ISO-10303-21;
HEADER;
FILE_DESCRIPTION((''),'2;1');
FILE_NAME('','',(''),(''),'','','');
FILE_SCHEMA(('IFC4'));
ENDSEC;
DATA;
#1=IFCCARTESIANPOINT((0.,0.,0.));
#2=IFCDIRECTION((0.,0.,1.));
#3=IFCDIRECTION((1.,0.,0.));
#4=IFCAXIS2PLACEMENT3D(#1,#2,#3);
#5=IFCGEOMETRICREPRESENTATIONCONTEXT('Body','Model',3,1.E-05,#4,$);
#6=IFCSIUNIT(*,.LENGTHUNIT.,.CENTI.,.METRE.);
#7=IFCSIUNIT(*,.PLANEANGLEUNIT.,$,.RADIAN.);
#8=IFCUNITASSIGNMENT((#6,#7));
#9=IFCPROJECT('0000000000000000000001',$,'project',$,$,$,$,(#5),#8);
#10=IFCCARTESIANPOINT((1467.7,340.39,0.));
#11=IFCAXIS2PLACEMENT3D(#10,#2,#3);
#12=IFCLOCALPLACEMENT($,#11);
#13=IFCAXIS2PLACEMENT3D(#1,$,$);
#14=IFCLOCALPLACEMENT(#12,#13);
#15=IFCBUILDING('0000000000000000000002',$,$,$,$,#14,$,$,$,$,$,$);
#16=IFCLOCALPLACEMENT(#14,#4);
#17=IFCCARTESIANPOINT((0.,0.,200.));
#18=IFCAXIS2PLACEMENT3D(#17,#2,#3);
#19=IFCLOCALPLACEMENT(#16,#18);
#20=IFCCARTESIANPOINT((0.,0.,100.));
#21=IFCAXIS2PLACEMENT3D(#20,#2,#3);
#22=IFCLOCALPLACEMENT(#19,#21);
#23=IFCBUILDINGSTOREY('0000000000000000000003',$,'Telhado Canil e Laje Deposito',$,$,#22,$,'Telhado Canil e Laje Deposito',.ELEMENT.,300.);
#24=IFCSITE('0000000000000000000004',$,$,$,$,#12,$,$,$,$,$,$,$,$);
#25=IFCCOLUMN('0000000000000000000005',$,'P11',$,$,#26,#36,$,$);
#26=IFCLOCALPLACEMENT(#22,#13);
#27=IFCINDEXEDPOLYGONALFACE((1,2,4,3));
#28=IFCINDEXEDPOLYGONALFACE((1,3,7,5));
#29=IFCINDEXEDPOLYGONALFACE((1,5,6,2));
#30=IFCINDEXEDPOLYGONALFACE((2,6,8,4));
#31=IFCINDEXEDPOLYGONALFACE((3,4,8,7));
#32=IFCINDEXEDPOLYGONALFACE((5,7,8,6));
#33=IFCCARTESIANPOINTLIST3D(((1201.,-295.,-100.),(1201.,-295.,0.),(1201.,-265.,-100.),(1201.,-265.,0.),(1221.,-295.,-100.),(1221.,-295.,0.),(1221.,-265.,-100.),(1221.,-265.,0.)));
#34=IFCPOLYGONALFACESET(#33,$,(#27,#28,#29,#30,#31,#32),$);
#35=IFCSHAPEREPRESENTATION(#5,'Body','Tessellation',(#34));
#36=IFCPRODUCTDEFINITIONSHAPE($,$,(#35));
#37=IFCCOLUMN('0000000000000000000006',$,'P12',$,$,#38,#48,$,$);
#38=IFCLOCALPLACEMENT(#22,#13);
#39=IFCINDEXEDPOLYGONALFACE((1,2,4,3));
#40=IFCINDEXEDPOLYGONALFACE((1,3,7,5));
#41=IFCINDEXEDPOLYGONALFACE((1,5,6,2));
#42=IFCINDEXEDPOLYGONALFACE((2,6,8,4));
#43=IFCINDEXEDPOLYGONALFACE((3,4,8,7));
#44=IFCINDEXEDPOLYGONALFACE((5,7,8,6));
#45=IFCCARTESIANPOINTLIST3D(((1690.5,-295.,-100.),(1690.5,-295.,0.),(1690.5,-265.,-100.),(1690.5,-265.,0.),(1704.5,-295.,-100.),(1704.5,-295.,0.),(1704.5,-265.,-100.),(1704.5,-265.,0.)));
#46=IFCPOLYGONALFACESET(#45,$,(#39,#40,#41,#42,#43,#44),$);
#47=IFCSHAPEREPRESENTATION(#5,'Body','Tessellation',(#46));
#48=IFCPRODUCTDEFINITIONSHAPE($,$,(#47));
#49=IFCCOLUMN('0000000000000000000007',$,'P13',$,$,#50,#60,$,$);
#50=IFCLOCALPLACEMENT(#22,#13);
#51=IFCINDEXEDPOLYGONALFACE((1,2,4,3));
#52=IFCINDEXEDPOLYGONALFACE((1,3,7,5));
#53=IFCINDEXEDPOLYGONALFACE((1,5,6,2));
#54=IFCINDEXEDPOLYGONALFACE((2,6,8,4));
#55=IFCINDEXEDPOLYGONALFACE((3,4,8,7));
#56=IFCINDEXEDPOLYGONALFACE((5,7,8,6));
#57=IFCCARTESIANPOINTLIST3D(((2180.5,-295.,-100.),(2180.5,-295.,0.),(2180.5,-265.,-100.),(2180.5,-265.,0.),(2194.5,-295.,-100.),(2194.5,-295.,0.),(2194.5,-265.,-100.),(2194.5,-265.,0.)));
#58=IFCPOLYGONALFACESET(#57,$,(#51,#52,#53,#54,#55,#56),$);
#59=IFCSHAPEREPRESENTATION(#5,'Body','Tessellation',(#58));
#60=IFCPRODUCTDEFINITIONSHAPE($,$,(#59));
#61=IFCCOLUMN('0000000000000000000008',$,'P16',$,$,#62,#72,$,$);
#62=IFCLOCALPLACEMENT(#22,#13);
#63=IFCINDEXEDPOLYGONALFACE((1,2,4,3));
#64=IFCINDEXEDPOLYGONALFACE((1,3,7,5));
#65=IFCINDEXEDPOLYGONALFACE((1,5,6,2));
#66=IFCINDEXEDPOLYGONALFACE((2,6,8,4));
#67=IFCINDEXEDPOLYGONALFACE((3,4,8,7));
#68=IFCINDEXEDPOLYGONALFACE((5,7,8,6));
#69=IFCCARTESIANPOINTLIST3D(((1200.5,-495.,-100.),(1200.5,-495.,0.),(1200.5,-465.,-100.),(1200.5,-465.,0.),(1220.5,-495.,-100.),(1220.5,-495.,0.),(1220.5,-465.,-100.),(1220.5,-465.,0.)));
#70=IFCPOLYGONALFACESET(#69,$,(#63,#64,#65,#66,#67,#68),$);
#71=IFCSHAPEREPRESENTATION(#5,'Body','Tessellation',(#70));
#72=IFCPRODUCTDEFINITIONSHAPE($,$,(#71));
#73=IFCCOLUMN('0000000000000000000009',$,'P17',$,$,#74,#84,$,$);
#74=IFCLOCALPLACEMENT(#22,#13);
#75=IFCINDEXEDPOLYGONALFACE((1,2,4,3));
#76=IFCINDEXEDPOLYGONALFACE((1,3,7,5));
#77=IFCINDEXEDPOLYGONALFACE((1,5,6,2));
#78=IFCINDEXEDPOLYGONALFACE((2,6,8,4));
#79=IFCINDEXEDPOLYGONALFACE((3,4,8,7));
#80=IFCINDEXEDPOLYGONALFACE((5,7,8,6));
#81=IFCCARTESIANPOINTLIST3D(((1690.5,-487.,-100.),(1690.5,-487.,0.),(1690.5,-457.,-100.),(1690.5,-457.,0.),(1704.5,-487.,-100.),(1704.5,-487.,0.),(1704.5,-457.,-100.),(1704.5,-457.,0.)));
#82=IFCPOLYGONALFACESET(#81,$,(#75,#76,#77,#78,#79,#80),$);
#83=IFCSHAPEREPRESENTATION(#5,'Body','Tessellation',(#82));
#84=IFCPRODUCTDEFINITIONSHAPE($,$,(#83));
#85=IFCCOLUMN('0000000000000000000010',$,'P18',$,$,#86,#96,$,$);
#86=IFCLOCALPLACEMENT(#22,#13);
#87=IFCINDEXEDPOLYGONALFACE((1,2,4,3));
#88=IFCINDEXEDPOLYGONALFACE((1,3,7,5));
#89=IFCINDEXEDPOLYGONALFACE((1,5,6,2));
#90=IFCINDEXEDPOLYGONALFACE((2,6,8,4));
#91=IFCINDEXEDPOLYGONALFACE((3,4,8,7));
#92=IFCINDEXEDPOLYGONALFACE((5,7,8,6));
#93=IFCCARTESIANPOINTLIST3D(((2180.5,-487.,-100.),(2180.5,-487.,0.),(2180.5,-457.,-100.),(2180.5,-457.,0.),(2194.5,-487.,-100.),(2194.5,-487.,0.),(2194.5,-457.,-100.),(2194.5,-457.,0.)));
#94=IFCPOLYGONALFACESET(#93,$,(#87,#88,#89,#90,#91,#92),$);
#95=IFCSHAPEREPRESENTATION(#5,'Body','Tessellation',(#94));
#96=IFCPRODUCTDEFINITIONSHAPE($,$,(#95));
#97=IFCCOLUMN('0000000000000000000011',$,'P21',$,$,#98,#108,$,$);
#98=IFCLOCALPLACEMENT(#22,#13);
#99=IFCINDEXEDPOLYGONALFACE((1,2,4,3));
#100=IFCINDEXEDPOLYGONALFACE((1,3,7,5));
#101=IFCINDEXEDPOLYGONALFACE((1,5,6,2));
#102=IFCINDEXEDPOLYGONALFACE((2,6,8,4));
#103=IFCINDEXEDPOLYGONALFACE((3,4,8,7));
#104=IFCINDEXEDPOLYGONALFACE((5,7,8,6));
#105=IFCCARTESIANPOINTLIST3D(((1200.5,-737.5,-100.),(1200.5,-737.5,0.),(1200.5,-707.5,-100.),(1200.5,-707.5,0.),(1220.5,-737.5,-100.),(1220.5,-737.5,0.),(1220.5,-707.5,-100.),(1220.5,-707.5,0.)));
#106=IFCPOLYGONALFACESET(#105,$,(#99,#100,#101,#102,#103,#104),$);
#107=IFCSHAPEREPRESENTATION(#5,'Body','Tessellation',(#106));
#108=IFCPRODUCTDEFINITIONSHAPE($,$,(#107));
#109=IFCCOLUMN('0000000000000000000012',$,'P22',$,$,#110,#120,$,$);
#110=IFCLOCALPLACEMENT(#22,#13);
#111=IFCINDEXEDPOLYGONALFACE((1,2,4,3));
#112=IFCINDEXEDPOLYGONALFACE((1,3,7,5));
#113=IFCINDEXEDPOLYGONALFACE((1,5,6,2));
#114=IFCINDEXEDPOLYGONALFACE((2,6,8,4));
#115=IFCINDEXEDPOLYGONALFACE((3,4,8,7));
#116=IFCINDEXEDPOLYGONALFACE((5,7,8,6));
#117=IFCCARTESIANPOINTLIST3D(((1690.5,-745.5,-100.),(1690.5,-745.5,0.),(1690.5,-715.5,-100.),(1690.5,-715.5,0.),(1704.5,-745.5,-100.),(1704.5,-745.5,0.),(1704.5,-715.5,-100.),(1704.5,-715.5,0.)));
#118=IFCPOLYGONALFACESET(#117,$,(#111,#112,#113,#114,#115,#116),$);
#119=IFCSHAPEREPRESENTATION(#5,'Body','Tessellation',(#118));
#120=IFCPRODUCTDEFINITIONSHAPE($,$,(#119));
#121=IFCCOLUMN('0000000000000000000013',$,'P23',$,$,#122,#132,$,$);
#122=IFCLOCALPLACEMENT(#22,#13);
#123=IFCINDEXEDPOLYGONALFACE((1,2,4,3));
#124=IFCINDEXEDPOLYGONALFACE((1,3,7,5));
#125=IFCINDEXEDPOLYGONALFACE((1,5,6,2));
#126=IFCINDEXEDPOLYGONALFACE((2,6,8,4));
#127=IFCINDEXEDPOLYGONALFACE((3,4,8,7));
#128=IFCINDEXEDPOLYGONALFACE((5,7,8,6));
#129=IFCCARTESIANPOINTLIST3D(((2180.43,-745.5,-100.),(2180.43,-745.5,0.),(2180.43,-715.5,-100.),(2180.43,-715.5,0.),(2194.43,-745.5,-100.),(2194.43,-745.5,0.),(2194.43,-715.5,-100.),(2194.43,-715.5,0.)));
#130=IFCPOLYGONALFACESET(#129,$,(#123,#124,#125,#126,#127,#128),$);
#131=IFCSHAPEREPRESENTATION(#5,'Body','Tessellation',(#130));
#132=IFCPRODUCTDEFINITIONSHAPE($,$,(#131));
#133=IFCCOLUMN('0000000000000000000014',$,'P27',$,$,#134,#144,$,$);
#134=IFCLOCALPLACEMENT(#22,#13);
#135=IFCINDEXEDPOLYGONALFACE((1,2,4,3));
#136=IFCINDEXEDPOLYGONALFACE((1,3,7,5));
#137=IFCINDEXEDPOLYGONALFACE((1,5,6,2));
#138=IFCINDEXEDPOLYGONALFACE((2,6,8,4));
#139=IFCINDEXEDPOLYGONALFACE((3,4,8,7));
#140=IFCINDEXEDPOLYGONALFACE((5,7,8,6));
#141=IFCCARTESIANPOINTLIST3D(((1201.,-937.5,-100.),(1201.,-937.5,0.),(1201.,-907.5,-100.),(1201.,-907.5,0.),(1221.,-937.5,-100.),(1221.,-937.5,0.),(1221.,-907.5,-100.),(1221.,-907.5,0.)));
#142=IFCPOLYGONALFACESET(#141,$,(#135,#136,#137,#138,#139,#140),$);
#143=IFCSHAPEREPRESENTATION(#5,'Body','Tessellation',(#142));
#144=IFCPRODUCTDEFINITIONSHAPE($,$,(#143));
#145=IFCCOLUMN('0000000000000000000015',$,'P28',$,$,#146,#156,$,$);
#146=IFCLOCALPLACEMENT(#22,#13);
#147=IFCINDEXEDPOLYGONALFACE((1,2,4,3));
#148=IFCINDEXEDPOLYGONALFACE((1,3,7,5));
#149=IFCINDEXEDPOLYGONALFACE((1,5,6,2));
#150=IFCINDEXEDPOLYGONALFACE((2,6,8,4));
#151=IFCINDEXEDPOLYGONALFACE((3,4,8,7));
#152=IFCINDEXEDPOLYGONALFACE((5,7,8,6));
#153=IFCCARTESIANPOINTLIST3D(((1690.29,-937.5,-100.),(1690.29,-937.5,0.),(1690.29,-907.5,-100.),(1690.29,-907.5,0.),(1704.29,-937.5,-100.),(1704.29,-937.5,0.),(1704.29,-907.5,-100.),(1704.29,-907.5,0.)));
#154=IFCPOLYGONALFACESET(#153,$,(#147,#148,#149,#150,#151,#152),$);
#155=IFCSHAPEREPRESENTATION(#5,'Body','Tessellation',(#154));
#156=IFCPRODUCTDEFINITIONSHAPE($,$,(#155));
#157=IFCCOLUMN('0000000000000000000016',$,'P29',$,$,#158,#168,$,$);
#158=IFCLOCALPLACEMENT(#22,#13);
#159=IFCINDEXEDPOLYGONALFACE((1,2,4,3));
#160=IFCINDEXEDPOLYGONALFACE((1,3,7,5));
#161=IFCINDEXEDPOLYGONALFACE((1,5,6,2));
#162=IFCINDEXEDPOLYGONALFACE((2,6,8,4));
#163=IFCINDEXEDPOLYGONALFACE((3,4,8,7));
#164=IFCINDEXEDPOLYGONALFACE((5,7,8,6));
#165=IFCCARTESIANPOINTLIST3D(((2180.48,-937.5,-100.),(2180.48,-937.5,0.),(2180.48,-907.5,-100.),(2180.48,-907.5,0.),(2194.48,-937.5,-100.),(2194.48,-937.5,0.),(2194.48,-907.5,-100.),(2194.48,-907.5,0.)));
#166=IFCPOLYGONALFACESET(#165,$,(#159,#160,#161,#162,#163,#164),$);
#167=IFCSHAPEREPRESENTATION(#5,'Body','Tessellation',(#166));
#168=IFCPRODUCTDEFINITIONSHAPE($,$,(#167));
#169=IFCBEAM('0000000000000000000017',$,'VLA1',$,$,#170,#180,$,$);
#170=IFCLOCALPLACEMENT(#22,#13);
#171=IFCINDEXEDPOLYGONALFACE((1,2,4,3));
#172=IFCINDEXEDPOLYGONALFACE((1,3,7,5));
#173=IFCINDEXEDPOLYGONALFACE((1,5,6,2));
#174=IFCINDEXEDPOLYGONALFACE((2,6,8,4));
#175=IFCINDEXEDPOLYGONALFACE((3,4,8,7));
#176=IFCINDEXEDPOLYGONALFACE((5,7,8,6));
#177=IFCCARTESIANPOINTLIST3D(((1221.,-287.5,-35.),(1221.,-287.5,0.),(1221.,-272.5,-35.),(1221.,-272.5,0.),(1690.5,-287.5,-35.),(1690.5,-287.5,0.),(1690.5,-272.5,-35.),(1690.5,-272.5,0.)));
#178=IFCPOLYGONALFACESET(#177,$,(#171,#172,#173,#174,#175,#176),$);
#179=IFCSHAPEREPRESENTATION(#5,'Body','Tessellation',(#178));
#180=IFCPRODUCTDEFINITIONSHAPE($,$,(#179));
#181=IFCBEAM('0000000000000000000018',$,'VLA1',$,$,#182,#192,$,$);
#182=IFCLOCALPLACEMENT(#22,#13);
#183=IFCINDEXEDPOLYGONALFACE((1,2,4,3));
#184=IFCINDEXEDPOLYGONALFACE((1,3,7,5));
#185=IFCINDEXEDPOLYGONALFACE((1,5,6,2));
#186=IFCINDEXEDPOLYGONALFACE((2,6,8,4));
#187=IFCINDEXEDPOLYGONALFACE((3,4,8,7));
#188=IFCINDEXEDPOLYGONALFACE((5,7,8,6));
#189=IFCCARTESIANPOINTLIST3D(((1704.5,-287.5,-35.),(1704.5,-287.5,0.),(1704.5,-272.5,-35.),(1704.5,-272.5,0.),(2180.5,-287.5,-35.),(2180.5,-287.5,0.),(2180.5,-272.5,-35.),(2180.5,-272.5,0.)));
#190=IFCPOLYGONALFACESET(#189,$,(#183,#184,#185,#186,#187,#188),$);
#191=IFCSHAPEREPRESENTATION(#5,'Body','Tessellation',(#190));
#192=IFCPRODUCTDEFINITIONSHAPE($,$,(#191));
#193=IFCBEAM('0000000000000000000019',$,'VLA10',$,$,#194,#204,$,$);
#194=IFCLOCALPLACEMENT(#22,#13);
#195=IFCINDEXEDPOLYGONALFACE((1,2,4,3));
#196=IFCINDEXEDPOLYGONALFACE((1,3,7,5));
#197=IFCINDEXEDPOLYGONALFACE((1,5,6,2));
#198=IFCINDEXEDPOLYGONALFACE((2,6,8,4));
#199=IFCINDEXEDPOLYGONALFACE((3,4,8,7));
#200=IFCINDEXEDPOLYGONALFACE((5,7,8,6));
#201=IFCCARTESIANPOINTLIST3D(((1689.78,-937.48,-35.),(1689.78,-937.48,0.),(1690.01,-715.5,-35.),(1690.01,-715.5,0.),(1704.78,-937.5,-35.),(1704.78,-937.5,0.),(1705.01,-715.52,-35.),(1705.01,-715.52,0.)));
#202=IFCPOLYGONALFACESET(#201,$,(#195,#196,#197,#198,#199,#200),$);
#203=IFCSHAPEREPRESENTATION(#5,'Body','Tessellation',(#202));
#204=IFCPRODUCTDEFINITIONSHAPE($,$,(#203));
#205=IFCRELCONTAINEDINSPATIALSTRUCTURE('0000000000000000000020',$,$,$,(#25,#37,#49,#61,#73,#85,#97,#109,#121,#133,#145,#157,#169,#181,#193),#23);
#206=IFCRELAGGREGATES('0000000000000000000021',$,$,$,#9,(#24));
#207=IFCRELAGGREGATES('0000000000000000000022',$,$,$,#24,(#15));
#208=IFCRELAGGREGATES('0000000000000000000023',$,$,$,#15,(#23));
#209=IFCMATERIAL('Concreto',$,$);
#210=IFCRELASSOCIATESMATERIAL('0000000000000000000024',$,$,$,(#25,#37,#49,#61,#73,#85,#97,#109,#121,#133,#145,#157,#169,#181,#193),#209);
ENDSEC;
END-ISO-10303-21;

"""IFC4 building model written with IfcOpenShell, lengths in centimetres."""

from ifc_helpers import new_model, si_unit, frame, origin, origin_with_axes, origin_2d_with_axis, place, context, project, spatial, rectangle, extrude, material, element, save


model = new_model("IFC4")

# Units and contexts
model_context = context("Model", 3, precision=1e-05, world=origin_with_axes(), identifier="Body")
ifc_project = project(units=[si_unit("LENGTHUNIT", "METRE", prefix="CENTI"), si_unit("PLANEANGLEUNIT", "RADIAN")], contexts=[model_context])

# Site, building, storey
site_placement = place(None, frame((1467.7, 340.39, 0.0), z_axis=(0.0, 0.0, 1.0), x_axis=(1.0, 0.0, 0.0)))
site = spatial("IfcSite", under=ifc_project, at=site_placement)
building_placement = place(site_placement, origin())
building = spatial("IfcBuilding", under=site, at=building_placement)
placement_1 = place(building_placement, origin_with_axes())
placement_2 = place(placement_1, frame((0.0, 0.0, 200.0), z_axis=(0.0, 0.0, 1.0), x_axis=(1.0, 0.0, 0.0)))
storey_placement = place(placement_2, frame((0.0, 0.0, 100.0), z_axis=(0.0, 0.0, 1.0), x_axis=(1.0, 0.0, 0.0)))
storey = spatial("IfcBuildingStorey", under=building, at=storey_placement, Name="Telhado Canil e Laje Deposito", LongName="Telhado Canil e Laje Deposito", CompositionType="ELEMENT", Elevation=300.0)

# Columns
ifc_material = material(Name="Concreto")
column_1_placement = place(storey_placement, frame((1211.0, -280.0, 0.0), z_axis=(0.0, 0.0, 1.0), x_axis=(1.0, 0.0, 0.0)))
element("IfcColumn", 1, at=column_1_placement, inside=storey, material=ifc_material, Name="P11", context=model_context, shape_type="SolidModel", body=[
    extrude(rectangle(XDim=20.0, YDim=30.0, at=origin_2d_with_axis()), origin_with_axes(), (0.0, 0.0, -1.0), 100.0),
])
for number, where, z_axis, x_axis, name in (
    (2, (1697.5, -280.0, 0.0), (0.0, 0.0, 1.0), (1.0, 0.0, 0.0), "P12"),
    (3, (2187.5, -280.0, 0.0), (0.0, 0.0, 1.0), (1.0, 0.0, 0.0), "P13"),
):
    element("IfcColumn", number, at=place(storey_placement, frame(where, z_axis=z_axis, x_axis=x_axis)), inside=storey, material=ifc_material, Name=name, context=model_context, shape_type="SolidModel", body=[
        extrude(rectangle(XDim=14.0, YDim=30.0, at=origin_2d_with_axis()), origin_with_axes(), (0.0, 0.0, -1.0), 100.0),
    ])
column_2_placement = place(storey_placement, frame((1210.5, -480.0, 0.0), z_axis=(0.0, 0.0, 1.0), x_axis=(1.0, 0.0, 0.0)))
element("IfcColumn", 4, at=column_2_placement, inside=storey, material=ifc_material, Name="P16", context=model_context, shape_type="SolidModel", body=[
    extrude(rectangle(XDim=20.0, YDim=30.0, at=origin_2d_with_axis()), origin_with_axes(), (0.0, 0.0, -1.0), 100.0),
])
for number, where, z_axis, x_axis, name in (
    (5, (1697.5, -472.0, 0.0), (0.0, 0.0, 1.0), (1.0, 0.0, 0.0), "P17"),
    (6, (2187.5, -472.0, 0.0), (0.0, 0.0, 1.0), (1.0, 0.0, 0.0), "P18"),
):
    element("IfcColumn", number, at=place(storey_placement, frame(where, z_axis=z_axis, x_axis=x_axis)), inside=storey, material=ifc_material, Name=name, context=model_context, shape_type="SolidModel", body=[
        extrude(rectangle(XDim=14.0, YDim=30.0, at=origin_2d_with_axis()), frame((0.0, 0.0, 0.0), z_axis=(0.0, 0.0, 1.0), x_axis=(-1.0, 0.0, 0.0)), (0.0, 0.0, -1.0), 100.0),
    ])
column_3_placement = place(storey_placement, frame((1210.5, -722.5, 0.0), z_axis=(0.0, 0.0, 1.0), x_axis=(1.0, 0.0, 0.0)))
element("IfcColumn", 7, at=column_3_placement, inside=storey, material=ifc_material, Name="P21", context=model_context, shape_type="SolidModel", body=[
    extrude(rectangle(XDim=20.0, YDim=30.0, at=origin_2d_with_axis()), origin_with_axes(), (0.0, 0.0, -1.0), 100.0),
])
column_4_placement = place(storey_placement, frame((1697.5, -730.5, 0.0), z_axis=(0.0, 0.0, 1.0), x_axis=(1.0, 0.0, 0.0)))
element("IfcColumn", 8, at=column_4_placement, inside=storey, material=ifc_material, Name="P22", context=model_context, shape_type="SolidModel", body=[
    extrude(rectangle(XDim=14.0, YDim=30.0, at=origin_2d_with_axis()), frame((0.0, 0.0, 0.0), z_axis=(0.0, 0.0, 1.0), x_axis=(-1.0, 0.0, 0.0)), (0.0, 0.0, -1.0), 100.0),
])
column_5_placement = place(storey_placement, frame((2187.43, -730.5, 0.0), z_axis=(0.0, 0.0, 1.0), x_axis=(1.0, 0.0, 0.0)))
element("IfcColumn", 9, at=column_5_placement, inside=storey, material=ifc_material, Name="P23", context=model_context, shape_type="SolidModel", body=[
    extrude(rectangle(XDim=14.0, YDim=30.0, at=origin_2d_with_axis()), origin_with_axes(), (0.0, 0.0, -1.0), 100.0),
])
column_6_placement = place(storey_placement, frame((1211.0, -922.5, 0.0), z_axis=(0.0, 0.0, 1.0), x_axis=(1.0, 0.0, 0.0)))
element("IfcColumn", 10, at=column_6_placement, inside=storey, material=ifc_material, Name="P27", context=model_context, shape_type="SolidModel", body=[
    extrude(rectangle(XDim=20.0, YDim=30.0, at=origin_2d_with_axis()), origin_with_axes(), (0.0, 0.0, -1.0), 100.0),
])
for number, where, z_axis, x_axis, name in (
    (11, (1697.29, -922.5, 0.0), (0.0, 0.0, 1.0), (1.0, 0.0, 0.0), "P28"),
    (12, (2187.48, -922.5, 0.0), (0.0, 0.0, 1.0), (1.0, 0.0, 0.0), "P29"),
):
    element("IfcColumn", number, at=place(storey_placement, frame(where, z_axis=z_axis, x_axis=x_axis)), inside=storey, material=ifc_material, Name=name, context=model_context, shape_type="SolidModel", body=[
        extrude(rectangle(XDim=14.0, YDim=30.0, at=origin_2d_with_axis()), origin_with_axes(), (0.0, 0.0, -1.0), 100.0),
    ])

# Beams
beam_1_placement = place(storey_placement, frame((1455.75, -280.0, 0.0), z_axis=(0.0, 0.0, 1.0), x_axis=(1.0, 0.0, 0.0)))
element("IfcBeam", 13, at=beam_1_placement, inside=storey, material=ifc_material, Name="VLA1", context=model_context, shape_type="SolidModel", body=[
    extrude(rectangle(XDim=15.0, YDim=35.0, at=origin_2d_with_axis()), frame((-234.75, 0.0, -17.5), z_axis=(1.0, 0.0, 0.0), x_axis=(0.0, 1.0, 0.0)), (0.0, 0.0, 1.0), 469.5),
])
beam_2_placement = place(storey_placement, frame((1942.5, -280.0, 0.0), z_axis=(0.0, 0.0, 1.0), x_axis=(1.0, 0.0, 0.0)))
element("IfcBeam", 14, at=beam_2_placement, inside=storey, material=ifc_material, Name="VLA1", context=model_context, shape_type="SolidModel", body=[
    extrude(rectangle(XDim=15.0, YDim=35.0, at=origin_2d_with_axis()), frame((-238.0, 0.0, -17.5), z_axis=(1.0, 0.0, 0.0), x_axis=(0.0, 1.0, 0.0)), (0.0, 0.0, 1.0), 476.0),
])
beam_3_placement = place(storey_placement, frame((1697.39, -826.5, 0.0), z_axis=(0.0, 0.0, 1.0), x_axis=(1.0, 0.0, 0.0)))
element("IfcBeam", 15, at=beam_3_placement, inside=storey, material=ifc_material, Name="VLA10", context=model_context, shape_type="SolidModel", body=[
    extrude(rectangle(XDim=15.0, YDim=35.0, at=origin_2d_with_axis()), frame((-0.12, -110.99, -17.5), z_axis=(0.001049, 1.0, 0.0), x_axis=(1.0, -0.001049, 0.0)), (0.0, 0.0, 1.0), 221.98),
])

save(model, "model.ifc")
